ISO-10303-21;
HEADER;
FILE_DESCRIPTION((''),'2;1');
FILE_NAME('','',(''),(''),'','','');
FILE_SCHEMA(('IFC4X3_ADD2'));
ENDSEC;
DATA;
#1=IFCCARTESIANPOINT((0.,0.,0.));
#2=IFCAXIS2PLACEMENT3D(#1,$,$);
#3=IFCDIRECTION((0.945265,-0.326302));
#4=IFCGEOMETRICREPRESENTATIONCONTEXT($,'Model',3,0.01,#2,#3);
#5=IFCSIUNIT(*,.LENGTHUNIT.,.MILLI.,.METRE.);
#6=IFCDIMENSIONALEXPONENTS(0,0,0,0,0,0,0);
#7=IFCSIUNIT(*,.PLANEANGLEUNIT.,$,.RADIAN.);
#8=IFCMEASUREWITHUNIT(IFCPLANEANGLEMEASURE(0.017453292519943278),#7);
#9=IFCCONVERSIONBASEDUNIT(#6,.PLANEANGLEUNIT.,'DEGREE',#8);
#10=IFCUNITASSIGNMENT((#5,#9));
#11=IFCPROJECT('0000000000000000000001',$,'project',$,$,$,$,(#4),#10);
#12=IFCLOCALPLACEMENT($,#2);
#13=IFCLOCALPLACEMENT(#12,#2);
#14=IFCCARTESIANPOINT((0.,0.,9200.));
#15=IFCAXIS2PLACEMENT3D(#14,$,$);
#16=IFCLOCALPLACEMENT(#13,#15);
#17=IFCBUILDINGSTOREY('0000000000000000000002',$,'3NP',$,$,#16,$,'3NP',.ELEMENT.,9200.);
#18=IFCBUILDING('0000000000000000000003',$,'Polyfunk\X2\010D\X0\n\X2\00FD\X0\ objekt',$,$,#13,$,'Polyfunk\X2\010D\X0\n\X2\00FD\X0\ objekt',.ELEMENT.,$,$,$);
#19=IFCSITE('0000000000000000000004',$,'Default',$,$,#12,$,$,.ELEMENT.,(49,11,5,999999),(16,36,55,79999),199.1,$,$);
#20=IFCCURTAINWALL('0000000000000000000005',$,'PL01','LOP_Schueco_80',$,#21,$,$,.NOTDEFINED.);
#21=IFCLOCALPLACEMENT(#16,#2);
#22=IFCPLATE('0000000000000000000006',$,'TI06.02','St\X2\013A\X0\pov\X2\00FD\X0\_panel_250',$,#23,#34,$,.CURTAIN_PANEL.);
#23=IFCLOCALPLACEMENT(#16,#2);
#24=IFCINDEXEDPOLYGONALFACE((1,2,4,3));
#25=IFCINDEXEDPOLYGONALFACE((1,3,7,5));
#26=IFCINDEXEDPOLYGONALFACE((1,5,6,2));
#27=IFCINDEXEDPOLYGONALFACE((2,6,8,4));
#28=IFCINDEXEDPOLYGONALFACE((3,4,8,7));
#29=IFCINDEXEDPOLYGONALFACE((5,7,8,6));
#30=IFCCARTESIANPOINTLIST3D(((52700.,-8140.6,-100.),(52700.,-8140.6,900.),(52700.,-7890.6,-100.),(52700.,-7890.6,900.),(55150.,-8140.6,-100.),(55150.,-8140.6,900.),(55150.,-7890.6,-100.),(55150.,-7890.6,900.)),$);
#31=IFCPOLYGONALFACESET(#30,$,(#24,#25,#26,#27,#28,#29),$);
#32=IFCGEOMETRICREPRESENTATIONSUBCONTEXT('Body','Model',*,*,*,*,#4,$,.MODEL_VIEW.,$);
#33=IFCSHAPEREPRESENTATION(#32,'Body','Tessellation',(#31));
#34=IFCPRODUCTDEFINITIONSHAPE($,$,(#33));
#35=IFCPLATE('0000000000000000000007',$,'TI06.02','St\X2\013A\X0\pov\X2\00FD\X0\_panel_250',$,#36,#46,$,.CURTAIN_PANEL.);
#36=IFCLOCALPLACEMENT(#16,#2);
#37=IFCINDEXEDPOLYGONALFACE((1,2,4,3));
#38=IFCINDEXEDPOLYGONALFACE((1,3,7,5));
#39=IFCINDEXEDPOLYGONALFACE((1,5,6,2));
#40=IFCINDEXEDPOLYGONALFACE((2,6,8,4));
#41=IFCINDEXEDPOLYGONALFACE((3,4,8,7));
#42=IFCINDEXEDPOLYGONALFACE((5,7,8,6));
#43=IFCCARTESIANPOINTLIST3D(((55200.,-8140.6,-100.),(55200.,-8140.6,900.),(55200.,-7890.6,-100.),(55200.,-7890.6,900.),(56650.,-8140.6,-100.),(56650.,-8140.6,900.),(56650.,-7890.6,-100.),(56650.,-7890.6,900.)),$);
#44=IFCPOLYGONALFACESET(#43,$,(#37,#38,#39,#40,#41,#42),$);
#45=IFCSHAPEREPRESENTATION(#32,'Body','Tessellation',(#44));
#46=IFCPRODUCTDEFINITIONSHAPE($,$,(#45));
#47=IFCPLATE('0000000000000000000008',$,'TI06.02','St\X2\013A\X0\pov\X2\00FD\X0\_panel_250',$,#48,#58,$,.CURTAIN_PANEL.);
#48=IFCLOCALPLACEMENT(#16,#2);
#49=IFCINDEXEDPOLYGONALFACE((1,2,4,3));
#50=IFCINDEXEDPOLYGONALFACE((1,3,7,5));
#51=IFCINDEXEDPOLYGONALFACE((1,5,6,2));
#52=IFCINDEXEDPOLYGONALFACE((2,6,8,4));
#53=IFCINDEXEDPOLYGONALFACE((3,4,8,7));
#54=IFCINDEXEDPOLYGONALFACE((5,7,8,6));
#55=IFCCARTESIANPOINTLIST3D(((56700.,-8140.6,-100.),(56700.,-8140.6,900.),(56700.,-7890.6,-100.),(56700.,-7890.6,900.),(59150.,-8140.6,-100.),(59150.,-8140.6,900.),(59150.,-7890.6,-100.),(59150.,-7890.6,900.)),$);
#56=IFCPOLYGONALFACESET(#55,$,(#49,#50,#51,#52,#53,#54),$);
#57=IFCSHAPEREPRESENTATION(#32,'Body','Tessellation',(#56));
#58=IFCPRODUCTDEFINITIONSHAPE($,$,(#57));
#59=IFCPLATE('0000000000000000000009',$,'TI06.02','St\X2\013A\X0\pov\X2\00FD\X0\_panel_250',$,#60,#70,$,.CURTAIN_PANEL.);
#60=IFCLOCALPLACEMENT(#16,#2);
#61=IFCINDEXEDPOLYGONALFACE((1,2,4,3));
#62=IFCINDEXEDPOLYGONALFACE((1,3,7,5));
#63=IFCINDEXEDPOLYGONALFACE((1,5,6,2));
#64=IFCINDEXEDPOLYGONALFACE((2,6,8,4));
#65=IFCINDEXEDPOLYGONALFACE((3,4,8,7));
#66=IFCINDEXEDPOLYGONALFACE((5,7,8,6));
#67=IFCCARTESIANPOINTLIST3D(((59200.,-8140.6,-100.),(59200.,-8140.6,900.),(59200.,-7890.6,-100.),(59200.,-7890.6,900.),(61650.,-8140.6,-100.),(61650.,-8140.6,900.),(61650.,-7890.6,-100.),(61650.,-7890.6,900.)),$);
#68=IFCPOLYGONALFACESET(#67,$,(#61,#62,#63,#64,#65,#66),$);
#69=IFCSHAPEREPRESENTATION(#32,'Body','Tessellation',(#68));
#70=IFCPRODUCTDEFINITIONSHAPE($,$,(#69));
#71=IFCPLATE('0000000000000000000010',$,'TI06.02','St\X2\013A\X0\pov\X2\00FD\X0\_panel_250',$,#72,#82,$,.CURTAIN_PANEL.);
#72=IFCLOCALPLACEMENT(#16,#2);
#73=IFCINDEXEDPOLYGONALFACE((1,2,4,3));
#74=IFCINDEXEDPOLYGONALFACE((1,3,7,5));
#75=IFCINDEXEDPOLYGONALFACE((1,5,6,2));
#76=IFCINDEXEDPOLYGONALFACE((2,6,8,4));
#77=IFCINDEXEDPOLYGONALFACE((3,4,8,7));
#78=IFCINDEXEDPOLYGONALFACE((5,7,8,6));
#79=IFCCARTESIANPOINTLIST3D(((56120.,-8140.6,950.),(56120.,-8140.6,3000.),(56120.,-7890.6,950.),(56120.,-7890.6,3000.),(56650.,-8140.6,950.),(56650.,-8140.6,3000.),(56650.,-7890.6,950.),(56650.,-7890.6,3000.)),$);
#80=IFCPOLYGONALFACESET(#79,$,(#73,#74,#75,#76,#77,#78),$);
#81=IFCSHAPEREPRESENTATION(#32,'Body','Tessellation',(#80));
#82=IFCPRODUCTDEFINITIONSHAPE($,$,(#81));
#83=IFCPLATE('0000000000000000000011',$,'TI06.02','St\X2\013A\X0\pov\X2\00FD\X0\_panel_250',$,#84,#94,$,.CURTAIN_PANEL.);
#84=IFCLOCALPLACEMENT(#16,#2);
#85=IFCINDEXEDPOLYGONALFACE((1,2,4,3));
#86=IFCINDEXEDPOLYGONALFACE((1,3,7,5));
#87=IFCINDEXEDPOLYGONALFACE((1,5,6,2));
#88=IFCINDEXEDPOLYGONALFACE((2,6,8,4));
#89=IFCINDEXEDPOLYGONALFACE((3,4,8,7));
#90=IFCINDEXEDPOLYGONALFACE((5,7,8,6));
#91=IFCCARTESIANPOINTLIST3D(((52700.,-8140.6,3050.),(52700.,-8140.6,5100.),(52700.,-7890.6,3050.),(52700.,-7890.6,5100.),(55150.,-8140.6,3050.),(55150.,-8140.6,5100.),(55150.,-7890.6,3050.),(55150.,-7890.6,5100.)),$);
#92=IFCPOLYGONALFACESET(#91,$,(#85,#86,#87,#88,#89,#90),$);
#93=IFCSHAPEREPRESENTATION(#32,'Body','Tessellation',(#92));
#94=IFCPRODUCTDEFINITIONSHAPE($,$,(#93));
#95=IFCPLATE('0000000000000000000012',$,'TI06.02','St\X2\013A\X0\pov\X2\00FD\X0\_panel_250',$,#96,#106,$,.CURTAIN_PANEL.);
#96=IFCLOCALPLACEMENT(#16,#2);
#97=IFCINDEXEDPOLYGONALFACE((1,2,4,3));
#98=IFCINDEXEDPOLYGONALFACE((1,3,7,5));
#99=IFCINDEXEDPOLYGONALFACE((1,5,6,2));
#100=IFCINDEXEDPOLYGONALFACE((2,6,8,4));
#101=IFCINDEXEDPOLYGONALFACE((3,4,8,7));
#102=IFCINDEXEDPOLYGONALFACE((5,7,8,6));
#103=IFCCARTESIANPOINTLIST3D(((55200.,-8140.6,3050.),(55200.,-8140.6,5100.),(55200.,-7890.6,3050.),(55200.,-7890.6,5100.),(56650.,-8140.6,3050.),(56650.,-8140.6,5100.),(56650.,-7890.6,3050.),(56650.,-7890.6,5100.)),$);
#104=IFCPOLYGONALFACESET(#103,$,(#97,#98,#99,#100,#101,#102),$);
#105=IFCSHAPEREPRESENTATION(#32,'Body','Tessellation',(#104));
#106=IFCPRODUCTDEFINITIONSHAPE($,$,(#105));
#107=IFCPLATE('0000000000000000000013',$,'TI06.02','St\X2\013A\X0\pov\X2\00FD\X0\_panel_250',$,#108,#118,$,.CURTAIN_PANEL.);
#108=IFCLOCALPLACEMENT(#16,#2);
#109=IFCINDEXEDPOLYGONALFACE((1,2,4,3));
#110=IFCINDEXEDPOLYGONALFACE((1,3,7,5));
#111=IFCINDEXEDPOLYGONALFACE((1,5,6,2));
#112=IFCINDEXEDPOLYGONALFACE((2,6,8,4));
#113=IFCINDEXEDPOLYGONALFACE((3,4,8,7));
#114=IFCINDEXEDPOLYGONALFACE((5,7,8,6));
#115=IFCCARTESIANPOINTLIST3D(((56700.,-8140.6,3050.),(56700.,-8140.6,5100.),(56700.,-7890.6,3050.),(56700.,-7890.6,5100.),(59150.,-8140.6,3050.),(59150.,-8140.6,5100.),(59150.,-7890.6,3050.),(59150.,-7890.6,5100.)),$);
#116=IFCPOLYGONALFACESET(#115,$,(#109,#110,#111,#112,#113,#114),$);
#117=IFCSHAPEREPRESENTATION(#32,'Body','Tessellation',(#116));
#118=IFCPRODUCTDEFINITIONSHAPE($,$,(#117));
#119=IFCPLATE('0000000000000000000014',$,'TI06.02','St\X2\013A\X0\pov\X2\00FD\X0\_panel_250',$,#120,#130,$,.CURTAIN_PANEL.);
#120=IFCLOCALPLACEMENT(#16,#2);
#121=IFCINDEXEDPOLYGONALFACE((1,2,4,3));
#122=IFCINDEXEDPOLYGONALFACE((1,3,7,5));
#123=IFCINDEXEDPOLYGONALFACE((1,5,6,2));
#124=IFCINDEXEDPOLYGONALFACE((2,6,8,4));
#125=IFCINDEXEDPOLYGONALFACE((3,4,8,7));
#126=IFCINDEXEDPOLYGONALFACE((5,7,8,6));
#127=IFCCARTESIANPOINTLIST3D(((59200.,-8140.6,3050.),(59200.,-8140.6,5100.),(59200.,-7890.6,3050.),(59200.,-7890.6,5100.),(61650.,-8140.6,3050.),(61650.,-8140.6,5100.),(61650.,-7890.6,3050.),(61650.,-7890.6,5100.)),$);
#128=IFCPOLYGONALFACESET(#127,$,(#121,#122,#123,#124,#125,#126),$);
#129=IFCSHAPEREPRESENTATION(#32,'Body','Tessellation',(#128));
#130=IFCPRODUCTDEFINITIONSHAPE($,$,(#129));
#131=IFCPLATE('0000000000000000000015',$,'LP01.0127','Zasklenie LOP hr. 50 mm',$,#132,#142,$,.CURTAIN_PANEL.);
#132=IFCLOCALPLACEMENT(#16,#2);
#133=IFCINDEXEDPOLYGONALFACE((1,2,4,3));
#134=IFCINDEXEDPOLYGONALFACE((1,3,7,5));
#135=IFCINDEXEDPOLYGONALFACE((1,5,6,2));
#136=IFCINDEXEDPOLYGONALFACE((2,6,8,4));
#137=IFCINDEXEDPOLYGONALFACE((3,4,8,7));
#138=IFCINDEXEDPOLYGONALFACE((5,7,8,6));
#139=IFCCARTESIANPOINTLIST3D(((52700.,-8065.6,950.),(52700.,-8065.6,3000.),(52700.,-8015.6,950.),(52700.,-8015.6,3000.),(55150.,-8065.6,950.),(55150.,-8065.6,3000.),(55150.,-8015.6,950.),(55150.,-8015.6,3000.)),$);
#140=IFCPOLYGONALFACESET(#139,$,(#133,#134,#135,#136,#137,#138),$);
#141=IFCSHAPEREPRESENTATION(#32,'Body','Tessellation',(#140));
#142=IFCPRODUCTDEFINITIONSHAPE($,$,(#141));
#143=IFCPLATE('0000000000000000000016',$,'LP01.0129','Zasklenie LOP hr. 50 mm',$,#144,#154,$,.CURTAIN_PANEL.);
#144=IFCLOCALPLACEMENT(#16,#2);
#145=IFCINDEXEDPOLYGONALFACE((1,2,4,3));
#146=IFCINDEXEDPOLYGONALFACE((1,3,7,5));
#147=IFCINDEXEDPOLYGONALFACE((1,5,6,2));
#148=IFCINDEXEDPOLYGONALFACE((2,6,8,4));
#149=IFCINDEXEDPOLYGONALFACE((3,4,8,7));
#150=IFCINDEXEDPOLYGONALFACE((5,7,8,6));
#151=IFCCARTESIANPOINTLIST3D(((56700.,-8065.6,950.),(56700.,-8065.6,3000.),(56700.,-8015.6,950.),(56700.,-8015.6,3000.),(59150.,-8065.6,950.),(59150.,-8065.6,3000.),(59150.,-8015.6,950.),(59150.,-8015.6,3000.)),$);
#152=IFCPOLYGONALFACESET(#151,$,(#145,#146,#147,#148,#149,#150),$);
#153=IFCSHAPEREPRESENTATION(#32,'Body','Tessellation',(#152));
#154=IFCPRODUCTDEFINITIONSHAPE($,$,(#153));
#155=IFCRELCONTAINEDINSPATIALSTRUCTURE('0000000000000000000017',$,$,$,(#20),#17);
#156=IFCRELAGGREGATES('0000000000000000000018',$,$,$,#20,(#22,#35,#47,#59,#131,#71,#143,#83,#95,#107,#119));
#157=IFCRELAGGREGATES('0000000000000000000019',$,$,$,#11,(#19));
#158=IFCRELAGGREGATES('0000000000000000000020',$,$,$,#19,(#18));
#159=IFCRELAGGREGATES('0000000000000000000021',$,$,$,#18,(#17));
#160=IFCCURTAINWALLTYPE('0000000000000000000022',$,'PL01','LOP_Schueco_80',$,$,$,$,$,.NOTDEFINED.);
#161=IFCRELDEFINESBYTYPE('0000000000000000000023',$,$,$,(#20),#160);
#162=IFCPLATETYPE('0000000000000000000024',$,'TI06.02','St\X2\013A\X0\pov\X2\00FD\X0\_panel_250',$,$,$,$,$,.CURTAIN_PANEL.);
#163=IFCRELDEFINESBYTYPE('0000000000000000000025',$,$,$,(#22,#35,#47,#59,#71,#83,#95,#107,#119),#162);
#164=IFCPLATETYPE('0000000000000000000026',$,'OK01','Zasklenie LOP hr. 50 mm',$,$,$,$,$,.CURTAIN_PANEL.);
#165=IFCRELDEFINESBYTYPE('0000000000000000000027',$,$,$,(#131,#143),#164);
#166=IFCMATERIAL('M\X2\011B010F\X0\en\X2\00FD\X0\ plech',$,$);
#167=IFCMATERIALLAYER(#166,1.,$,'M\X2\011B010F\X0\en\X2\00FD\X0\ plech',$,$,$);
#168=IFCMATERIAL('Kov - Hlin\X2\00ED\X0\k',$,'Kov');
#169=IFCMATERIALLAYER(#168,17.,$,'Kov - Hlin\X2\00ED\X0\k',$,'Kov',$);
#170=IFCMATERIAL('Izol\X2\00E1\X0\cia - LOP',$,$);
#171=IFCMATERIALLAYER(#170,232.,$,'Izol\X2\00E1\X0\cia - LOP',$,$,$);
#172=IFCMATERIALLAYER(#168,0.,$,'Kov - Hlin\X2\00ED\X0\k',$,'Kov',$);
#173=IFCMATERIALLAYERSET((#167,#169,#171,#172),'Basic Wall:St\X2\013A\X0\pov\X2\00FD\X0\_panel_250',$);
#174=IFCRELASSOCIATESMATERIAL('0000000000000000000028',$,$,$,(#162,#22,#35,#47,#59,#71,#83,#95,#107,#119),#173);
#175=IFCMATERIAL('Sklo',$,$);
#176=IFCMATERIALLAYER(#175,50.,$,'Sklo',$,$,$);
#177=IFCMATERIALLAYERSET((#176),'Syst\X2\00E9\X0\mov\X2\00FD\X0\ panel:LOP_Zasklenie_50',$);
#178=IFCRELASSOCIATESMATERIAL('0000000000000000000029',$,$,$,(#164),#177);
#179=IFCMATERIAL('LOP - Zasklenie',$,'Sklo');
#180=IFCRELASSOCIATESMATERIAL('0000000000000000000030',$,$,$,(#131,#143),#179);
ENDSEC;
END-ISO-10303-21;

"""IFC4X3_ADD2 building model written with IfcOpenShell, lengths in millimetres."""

from ifc_helpers import new_model, entity, si_unit, converted_unit, direction, frame, frame_2d, origin, origin_2d_with_axis, place, context, subcontext, project, spatial, rectangle, extrude, source, transform, mapped, material, layer, layer_set, layer_usage, type_object, type_shapes, element, aggregate, save


model = new_model("IFC4X3_ADD2")

# Units and contexts
model_context = context("Model", 3, precision=0.01, world=origin(), true_north=direction((0.945265, -0.326302)))
body_context = subcontext(model_context, "Body", "Model", "MODEL_VIEW")
ifc_project = project(units=[si_unit("LENGTHUNIT", "METRE", prefix="MILLI"), converted_unit("PLANEANGLEUNIT", "DEGREE", entity("IfcPlaneAngleMeasure", 0.017453292519943278), si_unit("PLANEANGLEUNIT", "RADIAN"), dimensions=[0, 0, 0, 0, 0, 0, 0])], contexts=[model_context])

# Site, building, storey
site_placement = place(None, origin())
site = spatial("IfcSite", under=ifc_project, at=site_placement, Name="Default", CompositionType="ELEMENT", RefLatitude=(49, 11, 5, 999999), RefLongitude=(16, 36, 55, 79999), RefElevation=199.1)
building_placement = place(site_placement, origin())
building = spatial("IfcBuilding", under=site, at=building_placement, Name="Polyfunkčný objekt", LongName="Polyfunkčný objekt", CompositionType="ELEMENT")
storey_placement = place(building_placement, frame((0.0, 0.0, 9200.0)))
storey = spatial("IfcBuildingStorey", under=building, at=storey_placement, Name="3NP", LongName="3NP", CompositionType="ELEMENT", Elevation=9200.0)

# Curtain wall, plates
curtain_wall_type = type_object("IfcCurtainWallType", Name="PL01", Description="LOP_Schueco_80", PredefinedType="NOTDEFINED")
curtain_wall_placement = place(storey_placement, frame((0.0, 0.0, -9200.0)))
curtain_wall = element("IfcCurtainWall", 1, at=curtain_wall_placement, inside=storey, type_object=curtain_wall_type, Name="PL01", Description="LOP_Schueco_80", PredefinedType="NOTDEFINED")
ifc_material_1 = material(Name="Měďený plech")
ifc_layer_1 = layer(ifc_material_1, 1.0, Name="Měďený plech")
ifc_material_2 = material(Name="Kov - Hliník", Category="Kov")
ifc_layer_2 = layer(ifc_material_2, 17.0, Name="Kov - Hliník", Category="Kov")
ifc_material_3 = material(Name="Izolácia - LOP")
ifc_layer_3 = layer(ifc_material_3, 232.0, Name="Izolácia - LOP")
ifc_layer_4 = layer(ifc_material_2, 0.0, Name="Kov - Hliník", Category="Kov")
ifc_layer_set_1 = layer_set([ifc_layer_1, ifc_layer_2, ifc_layer_3, ifc_layer_4], Name="Basic Wall:Stĺpový_panel_250")
ifc_layer_usage_1 = layer_usage(ifc_layer_set_1, "AXIS2", "POSITIVE", -125.0)
plate_type_1 = type_object("IfcPlateType", Name="TI06.02", Description="Stĺpový_panel_250", PredefinedType="CURTAIN_PANEL", material=ifc_layer_set_1)
plate_1_placement = place(storey_placement, frame((52700.0, -8015.6, -100.0)))
plate_1 = element("IfcPlate", 2, at=plate_1_placement, type_object=plate_type_1, material=ifc_layer_usage_1, Name="TI06.02", Description="Stĺpový_panel_250", PredefinedType="CURTAIN_PANEL", context=body_context, shape_type="SweptSolid", body=[
    extrude(rectangle(XDim=250.0, YDim=2450.0, at=frame_2d((0.0, 0.0), x_axis=(1.0, 0.0))), frame((1225.0, 0.0, 0.0), z_axis=(0.0, 0.0, 1.0), x_axis=(0.0, 1.0, 0.0)), (0.0, 0.0, 1.0), 1000.0),
])
ifc_layer_usage_2 = layer_usage(ifc_layer_set_1, "AXIS2", "POSITIVE", -125.0)
plate_2_placement = place(storey_placement, frame((55200.0, -8015.6, -100.0)))
plate_2 = element("IfcPlate", 3, at=plate_2_placement, type_object=plate_type_1, material=ifc_layer_usage_2, Name="TI06.02", Description="Stĺpový_panel_250", PredefinedType="CURTAIN_PANEL", context=body_context, shape_type="SweptSolid", body=[
    extrude(rectangle(XDim=250.0, YDim=1450.0, at=frame_2d((0.0, 0.0), x_axis=(1.0, 0.0))), frame((725.0, 0.0, 0.0), z_axis=(0.0, 0.0, 1.0), x_axis=(0.0, 1.0, 0.0)), (0.0, 0.0, 1.0), 1000.0),
])
ifc_layer_usage_3 = layer_usage(ifc_layer_set_1, "AXIS2", "POSITIVE", -125.0)
plate_3_placement = place(storey_placement, frame((56700.0, -8015.6, -100.0)))
plate_3 = element("IfcPlate", 4, at=plate_3_placement, type_object=plate_type_1, material=ifc_layer_usage_3, Name="TI06.02", Description="Stĺpový_panel_250", PredefinedType="CURTAIN_PANEL", context=body_context, shape_type="SweptSolid", body=[
    extrude(rectangle(XDim=250.0, YDim=2450.0, at=frame_2d((0.0, 0.0), x_axis=(1.0, 0.0))), frame((1225.0, 0.0, 0.0), z_axis=(0.0, 0.0, 1.0), x_axis=(0.0, 1.0, 0.0)), (0.0, 0.0, 1.0), 1000.0),
])
ifc_layer_usage_4 = layer_usage(ifc_layer_set_1, "AXIS2", "POSITIVE", -125.0)
plate_4_placement = place(storey_placement, frame((59200.0, -8015.6, -100.0)))
plate_4 = element("IfcPlate", 5, at=plate_4_placement, type_object=plate_type_1, material=ifc_layer_usage_4, Name="TI06.02", Description="Stĺpový_panel_250", PredefinedType="CURTAIN_PANEL", context=body_context, shape_type="SweptSolid", body=[
    extrude(rectangle(XDim=250.0, YDim=2450.0, at=frame_2d((0.0, 0.0), x_axis=(1.0, 0.0))), frame((1225.0, 0.0, 0.0), z_axis=(0.0, 0.0, 1.0), x_axis=(0.0, 1.0, 0.0)), (0.0, 0.0, 1.0), 1000.0),
])
ifc_layer_usage_5 = layer_usage(ifc_layer_set_1, "AXIS2", "POSITIVE", -125.0)
plate_5_placement = place(storey_placement, frame((56120.0, -8015.6, 950.0)))
plate_5 = element("IfcPlate", 6, at=plate_5_placement, type_object=plate_type_1, material=ifc_layer_usage_5, Name="TI06.02", Description="Stĺpový_panel_250", PredefinedType="CURTAIN_PANEL", context=body_context, shape_type="SweptSolid", body=[
    extrude(rectangle(XDim=250.0, YDim=530.0, at=origin_2d_with_axis()), frame((265.0, 0.0, 0.0), z_axis=(0.0, 0.0, 1.0), x_axis=(0.0, 1.0, 0.0)), (0.0, 0.0, 1.0), 2050.0),
])
ifc_layer_usage_6 = layer_usage(ifc_layer_set_1, "AXIS2", "POSITIVE", -125.0)
plate_6_placement = place(storey_placement, frame((52700.0, -8015.6, 3050.0)))
plate_6 = element("IfcPlate", 7, at=plate_6_placement, type_object=plate_type_1, material=ifc_layer_usage_6, Name="TI06.02", Description="Stĺpový_panel_250", PredefinedType="CURTAIN_PANEL", context=body_context, shape_type="SweptSolid", body=[
    extrude(rectangle(XDim=250.0, YDim=2450.0, at=frame_2d((0.0, 0.0), x_axis=(1.0, 0.0))), frame((1225.0, 0.0, 0.0), z_axis=(0.0, 0.0, 1.0), x_axis=(0.0, 1.0, 0.0)), (0.0, 0.0, 1.0), 2050.0),
])
ifc_layer_usage_7 = layer_usage(ifc_layer_set_1, "AXIS2", "POSITIVE", -125.0)
plate_7_placement = place(storey_placement, frame((55200.0, -8015.6, 3050.0)))
plate_7 = element("IfcPlate", 8, at=plate_7_placement, type_object=plate_type_1, material=ifc_layer_usage_7, Name="TI06.02", Description="Stĺpový_panel_250", PredefinedType="CURTAIN_PANEL", context=body_context, shape_type="SweptSolid", body=[
    extrude(rectangle(XDim=250.0, YDim=1450.0, at=frame_2d((0.0, 0.0), x_axis=(1.0, 0.0))), frame((725.0, 0.0, 0.0), z_axis=(0.0, 0.0, 1.0), x_axis=(0.0, 1.0, 0.0)), (0.0, 0.0, 1.0), 2050.0),
])
ifc_layer_usage_8 = layer_usage(ifc_layer_set_1, "AXIS2", "POSITIVE", -125.0)
plate_8_placement = place(storey_placement, frame((56700.0, -8015.6, 3050.0)))
plate_8 = element("IfcPlate", 9, at=plate_8_placement, type_object=plate_type_1, material=ifc_layer_usage_8, Name="TI06.02", Description="Stĺpový_panel_250", PredefinedType="CURTAIN_PANEL", context=body_context, shape_type="SweptSolid", body=[
    extrude(rectangle(XDim=250.0, YDim=2450.0, at=frame_2d((0.0, 0.0), x_axis=(1.0, 0.0))), frame((1225.0, 0.0, 0.0), z_axis=(0.0, 0.0, 1.0), x_axis=(0.0, 1.0, 0.0)), (0.0, 0.0, 1.0), 2050.0),
])
ifc_layer_usage_9 = layer_usage(ifc_layer_set_1, "AXIS2", "POSITIVE", -125.0)
plate_9_placement = place(storey_placement, frame((59200.0, -8015.6, 3050.0)))
plate_9 = element("IfcPlate", 10, at=plate_9_placement, type_object=plate_type_1, material=ifc_layer_usage_9, Name="TI06.02", Description="Stĺpový_panel_250", PredefinedType="CURTAIN_PANEL", context=body_context, shape_type="SweptSolid", body=[
    extrude(rectangle(XDim=250.0, YDim=2450.0, at=frame_2d((0.0, 0.0), x_axis=(1.0, 0.0))), frame((1225.0, 0.0, 0.0), z_axis=(0.0, 0.0, 1.0), x_axis=(0.0, 1.0, 0.0)), (0.0, 0.0, 1.0), 2050.0),
])
ifc_material_4 = material(Name="LOP - Zasklenie", Category="Sklo")
ifc_material_5 = material(Name="Sklo")
ifc_layer_5 = layer(ifc_material_5, 50.0, Name="Sklo")
ifc_layer_set_2 = layer_set([ifc_layer_5], Name="Systémový panel:LOP_Zasklenie_50")
plate_type_2 = type_object("IfcPlateType", Name="OK01", Description="Zasklenie LOP hr. 50 mm", PredefinedType="CURTAIN_PANEL", material=ifc_layer_set_2)
shared_shape_1 = source(origin(), body_context, "Body", "SweptSolid", [
    extrude(rectangle(XDim=50.0, YDim=2450.0, at=origin_2d_with_axis()), frame((0.0, -25.0, 0.0), z_axis=(0.0, 0.0, 1.0), x_axis=(0.0, 1.0, 0.0)), (0.0, 0.0, 1.0), 2050.0),
])
type_shapes(plate_type_2, [shared_shape_1])
plate_10_placement = place(curtain_wall_placement, frame((53925.0, -8015.6, 10150.0)))
plate_10 = element("IfcPlate", 11, at=plate_10_placement, type_object=plate_type_2, material=ifc_material_4, Name="LP01.0127", Description="Zasklenie LOP hr. 50 mm", PredefinedType="CURTAIN_PANEL", context=body_context, shape_type="MappedRepresentation", body=[
    mapped(shared_shape_1, transform((0.0, 0.0, 0.0), scale=1.0)),
])
plate_11_placement = place(curtain_wall_placement, frame((57925.0, -8015.6, 10150.0)))
plate_11 = element("IfcPlate", 12, at=plate_11_placement, type_object=plate_type_2, material=ifc_material_4, Name="LP01.0129", Description="Zasklenie LOP hr. 50 mm", PredefinedType="CURTAIN_PANEL", context=body_context, shape_type="MappedRepresentation", body=[
    mapped(shared_shape_1, transform((0.0, 0.0, 0.0), scale=1.0)),
])
aggregate(curtain_wall, [plate_1, plate_2, plate_3, plate_4, plate_10, plate_5, plate_11, plate_6, plate_7, plate_8, plate_9])

save(model, "model.ifc")
